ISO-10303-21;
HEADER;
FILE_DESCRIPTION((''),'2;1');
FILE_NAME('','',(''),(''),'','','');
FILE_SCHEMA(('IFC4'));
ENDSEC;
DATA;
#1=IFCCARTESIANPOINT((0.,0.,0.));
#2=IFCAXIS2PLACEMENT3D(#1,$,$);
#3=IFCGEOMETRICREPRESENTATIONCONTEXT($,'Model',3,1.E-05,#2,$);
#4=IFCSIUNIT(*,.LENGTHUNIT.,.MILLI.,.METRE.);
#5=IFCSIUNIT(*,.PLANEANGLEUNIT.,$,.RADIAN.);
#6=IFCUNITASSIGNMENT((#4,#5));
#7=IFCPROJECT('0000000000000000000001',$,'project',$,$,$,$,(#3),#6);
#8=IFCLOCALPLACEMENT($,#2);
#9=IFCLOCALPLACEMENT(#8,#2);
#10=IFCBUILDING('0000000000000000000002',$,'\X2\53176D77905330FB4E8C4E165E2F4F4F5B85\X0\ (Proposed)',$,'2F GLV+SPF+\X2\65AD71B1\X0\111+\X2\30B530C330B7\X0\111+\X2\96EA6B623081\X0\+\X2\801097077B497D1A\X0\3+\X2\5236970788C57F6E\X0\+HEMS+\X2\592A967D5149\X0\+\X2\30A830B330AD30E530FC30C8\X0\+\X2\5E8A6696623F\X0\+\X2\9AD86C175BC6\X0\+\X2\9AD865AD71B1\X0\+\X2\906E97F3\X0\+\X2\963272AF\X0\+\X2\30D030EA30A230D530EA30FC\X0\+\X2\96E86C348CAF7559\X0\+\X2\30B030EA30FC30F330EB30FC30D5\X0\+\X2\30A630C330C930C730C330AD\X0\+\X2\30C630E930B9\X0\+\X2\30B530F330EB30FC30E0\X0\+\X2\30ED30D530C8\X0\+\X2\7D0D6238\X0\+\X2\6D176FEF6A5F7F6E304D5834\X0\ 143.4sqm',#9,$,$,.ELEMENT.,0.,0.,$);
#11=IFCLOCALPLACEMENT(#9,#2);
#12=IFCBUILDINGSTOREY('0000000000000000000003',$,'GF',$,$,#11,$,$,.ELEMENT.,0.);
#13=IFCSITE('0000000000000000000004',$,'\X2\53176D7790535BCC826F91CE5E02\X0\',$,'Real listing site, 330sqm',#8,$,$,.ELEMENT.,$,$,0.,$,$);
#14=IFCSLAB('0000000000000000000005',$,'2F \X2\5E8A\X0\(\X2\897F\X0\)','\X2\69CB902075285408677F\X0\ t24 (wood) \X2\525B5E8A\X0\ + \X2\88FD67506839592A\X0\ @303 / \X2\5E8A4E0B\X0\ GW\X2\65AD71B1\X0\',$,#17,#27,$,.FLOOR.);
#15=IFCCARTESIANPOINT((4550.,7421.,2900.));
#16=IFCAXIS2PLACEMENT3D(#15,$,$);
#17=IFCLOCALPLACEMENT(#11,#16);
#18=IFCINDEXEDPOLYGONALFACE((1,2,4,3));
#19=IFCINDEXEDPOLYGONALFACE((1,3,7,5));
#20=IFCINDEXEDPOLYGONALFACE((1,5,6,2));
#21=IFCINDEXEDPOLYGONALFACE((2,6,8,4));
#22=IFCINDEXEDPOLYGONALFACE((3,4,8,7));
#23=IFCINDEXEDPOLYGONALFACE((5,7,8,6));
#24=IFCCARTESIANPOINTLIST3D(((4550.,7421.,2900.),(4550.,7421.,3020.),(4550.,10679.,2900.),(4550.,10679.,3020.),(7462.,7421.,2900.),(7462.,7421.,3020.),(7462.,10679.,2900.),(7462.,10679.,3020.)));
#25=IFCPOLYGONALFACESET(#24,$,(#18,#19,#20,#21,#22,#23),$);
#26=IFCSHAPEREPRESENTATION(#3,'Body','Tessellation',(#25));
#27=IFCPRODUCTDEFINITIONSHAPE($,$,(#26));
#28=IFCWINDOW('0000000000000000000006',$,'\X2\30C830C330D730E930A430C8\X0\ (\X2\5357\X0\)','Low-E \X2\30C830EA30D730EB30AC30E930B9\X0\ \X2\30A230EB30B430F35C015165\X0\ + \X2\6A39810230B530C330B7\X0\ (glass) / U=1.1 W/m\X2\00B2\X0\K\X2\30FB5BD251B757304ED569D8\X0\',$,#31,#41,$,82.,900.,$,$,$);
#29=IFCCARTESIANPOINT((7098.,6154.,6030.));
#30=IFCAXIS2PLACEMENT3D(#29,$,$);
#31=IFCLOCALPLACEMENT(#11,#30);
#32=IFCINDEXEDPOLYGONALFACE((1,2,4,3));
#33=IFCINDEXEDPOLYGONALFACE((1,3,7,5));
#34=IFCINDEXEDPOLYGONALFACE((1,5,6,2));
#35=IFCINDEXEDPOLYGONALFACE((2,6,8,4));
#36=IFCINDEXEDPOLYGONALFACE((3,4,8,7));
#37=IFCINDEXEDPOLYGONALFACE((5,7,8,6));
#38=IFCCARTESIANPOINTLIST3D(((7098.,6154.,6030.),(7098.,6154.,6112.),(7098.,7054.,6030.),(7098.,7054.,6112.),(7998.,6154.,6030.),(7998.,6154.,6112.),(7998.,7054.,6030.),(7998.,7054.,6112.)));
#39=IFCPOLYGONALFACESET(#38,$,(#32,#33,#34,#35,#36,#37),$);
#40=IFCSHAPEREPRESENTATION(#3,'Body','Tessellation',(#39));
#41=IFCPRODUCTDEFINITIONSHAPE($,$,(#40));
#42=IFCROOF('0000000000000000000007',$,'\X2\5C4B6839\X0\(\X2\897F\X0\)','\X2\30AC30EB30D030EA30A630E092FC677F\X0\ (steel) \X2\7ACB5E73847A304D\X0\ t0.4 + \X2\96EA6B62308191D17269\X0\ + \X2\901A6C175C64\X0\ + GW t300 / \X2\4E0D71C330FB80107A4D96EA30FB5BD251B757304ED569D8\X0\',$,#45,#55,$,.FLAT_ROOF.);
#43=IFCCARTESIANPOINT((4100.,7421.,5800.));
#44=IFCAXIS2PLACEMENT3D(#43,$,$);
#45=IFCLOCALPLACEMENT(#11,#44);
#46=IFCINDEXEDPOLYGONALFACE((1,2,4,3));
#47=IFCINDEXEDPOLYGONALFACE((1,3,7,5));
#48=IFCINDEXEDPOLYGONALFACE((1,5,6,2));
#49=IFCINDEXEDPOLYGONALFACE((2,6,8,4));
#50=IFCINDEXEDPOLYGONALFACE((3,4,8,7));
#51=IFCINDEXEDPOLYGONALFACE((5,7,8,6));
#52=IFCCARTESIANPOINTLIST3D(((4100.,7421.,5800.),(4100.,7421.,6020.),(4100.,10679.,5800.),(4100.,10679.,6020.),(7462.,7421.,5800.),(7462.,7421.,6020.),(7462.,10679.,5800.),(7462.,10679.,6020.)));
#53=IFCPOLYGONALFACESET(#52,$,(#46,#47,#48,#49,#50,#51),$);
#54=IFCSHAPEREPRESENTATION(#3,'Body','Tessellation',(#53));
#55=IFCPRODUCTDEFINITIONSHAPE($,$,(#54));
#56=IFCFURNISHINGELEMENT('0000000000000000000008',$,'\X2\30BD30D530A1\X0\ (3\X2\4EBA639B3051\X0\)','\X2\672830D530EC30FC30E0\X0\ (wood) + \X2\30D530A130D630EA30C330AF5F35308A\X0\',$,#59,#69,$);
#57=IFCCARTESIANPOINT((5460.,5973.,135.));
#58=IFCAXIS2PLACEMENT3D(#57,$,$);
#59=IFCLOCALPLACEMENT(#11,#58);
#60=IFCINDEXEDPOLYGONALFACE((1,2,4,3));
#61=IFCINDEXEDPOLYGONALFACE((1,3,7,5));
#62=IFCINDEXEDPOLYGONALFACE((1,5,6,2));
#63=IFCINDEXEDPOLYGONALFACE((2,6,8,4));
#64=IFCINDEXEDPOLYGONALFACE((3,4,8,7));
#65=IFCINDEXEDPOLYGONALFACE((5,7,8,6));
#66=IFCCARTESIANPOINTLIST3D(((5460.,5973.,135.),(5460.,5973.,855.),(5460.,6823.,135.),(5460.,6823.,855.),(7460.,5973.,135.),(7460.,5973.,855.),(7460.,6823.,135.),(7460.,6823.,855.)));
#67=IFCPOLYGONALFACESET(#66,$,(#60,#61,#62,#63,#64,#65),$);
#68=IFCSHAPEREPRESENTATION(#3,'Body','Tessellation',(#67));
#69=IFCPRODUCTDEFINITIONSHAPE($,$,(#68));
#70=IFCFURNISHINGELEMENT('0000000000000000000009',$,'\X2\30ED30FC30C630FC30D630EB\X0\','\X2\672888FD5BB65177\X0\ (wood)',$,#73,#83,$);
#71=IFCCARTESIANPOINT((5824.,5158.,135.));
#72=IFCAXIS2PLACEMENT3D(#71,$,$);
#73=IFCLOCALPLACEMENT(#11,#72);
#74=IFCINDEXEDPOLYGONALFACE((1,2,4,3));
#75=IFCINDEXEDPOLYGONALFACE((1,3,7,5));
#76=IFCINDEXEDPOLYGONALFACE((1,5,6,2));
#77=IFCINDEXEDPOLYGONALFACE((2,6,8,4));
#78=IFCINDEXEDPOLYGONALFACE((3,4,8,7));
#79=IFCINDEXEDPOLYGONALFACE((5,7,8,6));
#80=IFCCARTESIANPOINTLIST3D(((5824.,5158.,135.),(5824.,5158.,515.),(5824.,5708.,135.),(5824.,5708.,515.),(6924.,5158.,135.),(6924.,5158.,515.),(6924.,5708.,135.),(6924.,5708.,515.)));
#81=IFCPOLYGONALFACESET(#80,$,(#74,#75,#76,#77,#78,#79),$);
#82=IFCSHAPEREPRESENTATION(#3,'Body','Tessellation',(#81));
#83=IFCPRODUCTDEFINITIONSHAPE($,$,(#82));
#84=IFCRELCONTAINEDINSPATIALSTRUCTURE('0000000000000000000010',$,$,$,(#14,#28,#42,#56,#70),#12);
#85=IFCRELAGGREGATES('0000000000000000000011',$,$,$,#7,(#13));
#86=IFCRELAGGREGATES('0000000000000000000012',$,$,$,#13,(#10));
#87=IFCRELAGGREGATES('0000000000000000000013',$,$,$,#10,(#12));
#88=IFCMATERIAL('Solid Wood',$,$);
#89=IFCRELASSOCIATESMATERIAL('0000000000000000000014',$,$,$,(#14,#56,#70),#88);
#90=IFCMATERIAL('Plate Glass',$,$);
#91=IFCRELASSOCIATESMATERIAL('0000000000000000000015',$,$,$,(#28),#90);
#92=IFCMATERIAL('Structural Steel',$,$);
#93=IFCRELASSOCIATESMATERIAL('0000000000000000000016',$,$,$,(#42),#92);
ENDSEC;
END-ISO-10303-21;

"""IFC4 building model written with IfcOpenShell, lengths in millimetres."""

from ifc_helpers import new_model, si_unit, frame, frame_2d, origin, place, context, project, spatial, rectangle, extrude, material, element, save


model = new_model("IFC4")

# Units and contexts
model_context = context("Model", 3, precision=1e-05, world=origin())
ifc_project = project(units=[si_unit("LENGTHUNIT", "METRE", prefix="MILLI"), si_unit("PLANEANGLEUNIT", "RADIAN")], contexts=[model_context])

# Site, building, storey
site_placement = place(None, origin())
site = spatial("IfcSite", under=ifc_project, at=site_placement, Name="北海道富良野市", ObjectType="Real listing site, 330sqm", CompositionType="ELEMENT", RefElevation=0.0)
building_placement = place(site_placement, origin())
building = spatial("IfcBuilding", under=site, at=building_placement, Name="北海道・二世帯住宅 (Proposed)", ObjectType="2F GLV+SPF+断熱111+サッシ111+雪止め+耐震等級3+制震装置+HEMS+太陽光+エコキュート+床暖房+高気密+高断熱+遮音+防犯+バリアフリー+雨水貯留+グリーンルーフ+ウッドデッキ+テラス+サンルーム+ロフト+納戸+洗濯機置き場 143.4sqm", CompositionType="ELEMENT", ElevationOfRefHeight=0.0, ElevationOfTerrain=0.0)
storey_placement = place(building_placement, origin())
storey = spatial("IfcBuildingStorey", under=building, at=storey_placement, Name="GF", CompositionType="ELEMENT", Elevation=0.0)

# Shared definitions
ifc_material_1 = material(Name="Solid Wood")

# Slab
slab_1_placement = place(storey_placement, frame((4550.0, 7421.0, 2900.0)))
element("IfcSlab", 1, at=slab_1_placement, inside=storey, material=ifc_material_1, Name="2F 床(西)", Description="構造用合板 t24 (wood) 剛床 + 製材根太 @303 / 床下 GW断熱", PredefinedType="FLOOR", context=model_context, shape_type="SweptSolid", body=[
    extrude(rectangle(XDim=2912.0, YDim=3258.0, at=frame_2d((1456.0, 1629.0))), frame((4550.0, 7421.0, 2900.0)), (0.0, 0.0, 1.0), 120.0),
])

# Window
ifc_material_2 = material(Name="Plate Glass")
window_placement = place(storey_placement, frame((7098.0, 6154.0, 6030.0)))
element("IfcWindow", 2, at=window_placement, inside=storey, material=ifc_material_2, Name="トップライト (南)", Description="Low-E トリプルガラス アルゴン封入 + 樹脂サッシ (glass) / U=1.1 W/m²K・寒冷地仕様", OverallHeight=82.0, OverallWidth=900.0, context=model_context, shape_type="SweptSolid", body=[
    extrude(rectangle(XDim=900.0, YDim=900.0, at=frame_2d((450.0, 450.0))), frame((7098.0, 6154.0, 6030.0)), (0.0, 0.0, 1.0), 82.0),
])

# Roof
ifc_material_3 = material(Name="Structural Steel")
for number, where, name in (
    (3, (4100.0, 7421.0, 5800.0), "屋根(西)"),
):
    element("IfcRoof", number, at=place(storey_placement, frame(where)), inside=storey, material=ifc_material_3, Name=name, Description="ガルバリウム鋼板 (steel) 立平葺き t0.4 + 雪止め金物 + 通気層 + GW t300 / 不燃・耐積雪・寒冷地仕様", PredefinedType="FLAT_ROOF", context=model_context, shape_type="SweptSolid", body=[
        extrude(rectangle(XDim=3362.0, YDim=3258.0, at=frame_2d((1681.0, 1629.0))), frame((4100.0, 7421.0, 5800.0)), (0.0, 0.0, 1.0), 220.0),
    ])

# Furnishing elements
furnishing_1_placement = place(storey_placement, frame((5460.0, 5973.0, 135.0)))
element("IfcFurnishingElement", 4, at=furnishing_1_placement, inside=storey, material=ifc_material_1, Name="ソファ (3人掛け)", Description="木フレーム (wood) + ファブリック張り", context=model_context, shape_type="SweptSolid", body=[
    extrude(rectangle(XDim=2000.0, YDim=850.0, at=frame_2d((1000.0, 425.0))), frame((5460.0, 5973.0, 135.0)), (0.0, 0.0, 1.0), 720.0),
])
furnishing_2_placement = place(storey_placement, frame((5824.0, 5158.0, 135.0)))
element("IfcFurnishingElement", 5, at=furnishing_2_placement, inside=storey, material=ifc_material_1, Name="ローテーブル", Description="木製家具 (wood)", context=model_context, shape_type="SweptSolid", body=[
    extrude(rectangle(XDim=1100.0, YDim=550.0, at=frame_2d((550.0, 275.0))), frame((5824.0, 5158.0, 135.0)), (0.0, 0.0, 1.0), 380.0),
])

save(model, "model.ifc")
